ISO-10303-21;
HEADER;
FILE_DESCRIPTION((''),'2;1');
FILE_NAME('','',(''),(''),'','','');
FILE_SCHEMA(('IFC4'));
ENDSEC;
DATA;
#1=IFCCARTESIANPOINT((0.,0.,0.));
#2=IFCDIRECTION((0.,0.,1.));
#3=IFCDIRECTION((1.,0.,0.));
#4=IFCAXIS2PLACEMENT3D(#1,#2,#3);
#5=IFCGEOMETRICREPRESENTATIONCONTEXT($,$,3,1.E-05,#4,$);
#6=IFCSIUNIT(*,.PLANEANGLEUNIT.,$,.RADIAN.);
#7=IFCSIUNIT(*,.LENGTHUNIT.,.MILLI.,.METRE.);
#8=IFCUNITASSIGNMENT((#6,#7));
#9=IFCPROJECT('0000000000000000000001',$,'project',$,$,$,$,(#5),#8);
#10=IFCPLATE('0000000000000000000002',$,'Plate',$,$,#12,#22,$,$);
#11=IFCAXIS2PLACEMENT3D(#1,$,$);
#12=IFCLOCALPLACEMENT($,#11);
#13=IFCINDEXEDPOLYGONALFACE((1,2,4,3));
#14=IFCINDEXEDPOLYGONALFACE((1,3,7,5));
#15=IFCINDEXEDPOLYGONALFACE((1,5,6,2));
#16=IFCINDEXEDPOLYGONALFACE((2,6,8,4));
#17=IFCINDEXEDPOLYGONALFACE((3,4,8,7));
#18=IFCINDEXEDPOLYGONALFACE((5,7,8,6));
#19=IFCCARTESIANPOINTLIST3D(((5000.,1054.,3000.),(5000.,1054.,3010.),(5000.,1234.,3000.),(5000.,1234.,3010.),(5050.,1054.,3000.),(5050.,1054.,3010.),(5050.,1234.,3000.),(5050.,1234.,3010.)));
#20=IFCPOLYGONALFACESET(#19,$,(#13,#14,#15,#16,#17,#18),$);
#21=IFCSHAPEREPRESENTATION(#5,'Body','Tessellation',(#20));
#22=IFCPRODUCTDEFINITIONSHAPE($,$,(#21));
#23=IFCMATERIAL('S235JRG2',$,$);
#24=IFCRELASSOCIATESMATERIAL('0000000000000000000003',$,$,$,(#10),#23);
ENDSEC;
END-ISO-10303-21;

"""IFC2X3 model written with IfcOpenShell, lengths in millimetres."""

from ifc_helpers import new_model, si_unit, frame, origin_with_axes, place, context, project, polyline, outline, extrude, material, element, save


model = new_model("IFC2X3")

# Units and contexts
context_of_model = context(None, 3, precision=1e-05, world=origin_with_axes())
ifc_project = project(units=[si_unit("PLANEANGLEUNIT", "RADIAN"), si_unit("LENGTHUNIT", "METRE", prefix="MILLI")], contexts=[context_of_model])

# Shared definitions
ifc_material = material(Name="S235JRG2")

# Plate
placement_1 = place(None, origin_with_axes())
plate_placement = place(placement_1, frame((5000.0, 1054.0, 3010.0), z_axis=(1.0, 0.0, 0.0), x_axis=(0.0, 0.0, -1.0)))
element("IfcPlate", 1, at=plate_placement, material=ifc_material, Name="Plate", context=context_of_model, shape_type="SweptSolid", body=[
    extrude(outline(polyline([(0.0, 0.0), (180.0, 0.0), (180.0, 50.0), (0.0, 50.0), (0.0, 0.0)])), frame((0.0, 0.0, 0.0), z_axis=(1.0, 0.0, 0.0), x_axis=(0.0, 1.0, 0.0)), (0.0, 0.0, 1.0), 10.0),
])

save(model, "model.ifc")
